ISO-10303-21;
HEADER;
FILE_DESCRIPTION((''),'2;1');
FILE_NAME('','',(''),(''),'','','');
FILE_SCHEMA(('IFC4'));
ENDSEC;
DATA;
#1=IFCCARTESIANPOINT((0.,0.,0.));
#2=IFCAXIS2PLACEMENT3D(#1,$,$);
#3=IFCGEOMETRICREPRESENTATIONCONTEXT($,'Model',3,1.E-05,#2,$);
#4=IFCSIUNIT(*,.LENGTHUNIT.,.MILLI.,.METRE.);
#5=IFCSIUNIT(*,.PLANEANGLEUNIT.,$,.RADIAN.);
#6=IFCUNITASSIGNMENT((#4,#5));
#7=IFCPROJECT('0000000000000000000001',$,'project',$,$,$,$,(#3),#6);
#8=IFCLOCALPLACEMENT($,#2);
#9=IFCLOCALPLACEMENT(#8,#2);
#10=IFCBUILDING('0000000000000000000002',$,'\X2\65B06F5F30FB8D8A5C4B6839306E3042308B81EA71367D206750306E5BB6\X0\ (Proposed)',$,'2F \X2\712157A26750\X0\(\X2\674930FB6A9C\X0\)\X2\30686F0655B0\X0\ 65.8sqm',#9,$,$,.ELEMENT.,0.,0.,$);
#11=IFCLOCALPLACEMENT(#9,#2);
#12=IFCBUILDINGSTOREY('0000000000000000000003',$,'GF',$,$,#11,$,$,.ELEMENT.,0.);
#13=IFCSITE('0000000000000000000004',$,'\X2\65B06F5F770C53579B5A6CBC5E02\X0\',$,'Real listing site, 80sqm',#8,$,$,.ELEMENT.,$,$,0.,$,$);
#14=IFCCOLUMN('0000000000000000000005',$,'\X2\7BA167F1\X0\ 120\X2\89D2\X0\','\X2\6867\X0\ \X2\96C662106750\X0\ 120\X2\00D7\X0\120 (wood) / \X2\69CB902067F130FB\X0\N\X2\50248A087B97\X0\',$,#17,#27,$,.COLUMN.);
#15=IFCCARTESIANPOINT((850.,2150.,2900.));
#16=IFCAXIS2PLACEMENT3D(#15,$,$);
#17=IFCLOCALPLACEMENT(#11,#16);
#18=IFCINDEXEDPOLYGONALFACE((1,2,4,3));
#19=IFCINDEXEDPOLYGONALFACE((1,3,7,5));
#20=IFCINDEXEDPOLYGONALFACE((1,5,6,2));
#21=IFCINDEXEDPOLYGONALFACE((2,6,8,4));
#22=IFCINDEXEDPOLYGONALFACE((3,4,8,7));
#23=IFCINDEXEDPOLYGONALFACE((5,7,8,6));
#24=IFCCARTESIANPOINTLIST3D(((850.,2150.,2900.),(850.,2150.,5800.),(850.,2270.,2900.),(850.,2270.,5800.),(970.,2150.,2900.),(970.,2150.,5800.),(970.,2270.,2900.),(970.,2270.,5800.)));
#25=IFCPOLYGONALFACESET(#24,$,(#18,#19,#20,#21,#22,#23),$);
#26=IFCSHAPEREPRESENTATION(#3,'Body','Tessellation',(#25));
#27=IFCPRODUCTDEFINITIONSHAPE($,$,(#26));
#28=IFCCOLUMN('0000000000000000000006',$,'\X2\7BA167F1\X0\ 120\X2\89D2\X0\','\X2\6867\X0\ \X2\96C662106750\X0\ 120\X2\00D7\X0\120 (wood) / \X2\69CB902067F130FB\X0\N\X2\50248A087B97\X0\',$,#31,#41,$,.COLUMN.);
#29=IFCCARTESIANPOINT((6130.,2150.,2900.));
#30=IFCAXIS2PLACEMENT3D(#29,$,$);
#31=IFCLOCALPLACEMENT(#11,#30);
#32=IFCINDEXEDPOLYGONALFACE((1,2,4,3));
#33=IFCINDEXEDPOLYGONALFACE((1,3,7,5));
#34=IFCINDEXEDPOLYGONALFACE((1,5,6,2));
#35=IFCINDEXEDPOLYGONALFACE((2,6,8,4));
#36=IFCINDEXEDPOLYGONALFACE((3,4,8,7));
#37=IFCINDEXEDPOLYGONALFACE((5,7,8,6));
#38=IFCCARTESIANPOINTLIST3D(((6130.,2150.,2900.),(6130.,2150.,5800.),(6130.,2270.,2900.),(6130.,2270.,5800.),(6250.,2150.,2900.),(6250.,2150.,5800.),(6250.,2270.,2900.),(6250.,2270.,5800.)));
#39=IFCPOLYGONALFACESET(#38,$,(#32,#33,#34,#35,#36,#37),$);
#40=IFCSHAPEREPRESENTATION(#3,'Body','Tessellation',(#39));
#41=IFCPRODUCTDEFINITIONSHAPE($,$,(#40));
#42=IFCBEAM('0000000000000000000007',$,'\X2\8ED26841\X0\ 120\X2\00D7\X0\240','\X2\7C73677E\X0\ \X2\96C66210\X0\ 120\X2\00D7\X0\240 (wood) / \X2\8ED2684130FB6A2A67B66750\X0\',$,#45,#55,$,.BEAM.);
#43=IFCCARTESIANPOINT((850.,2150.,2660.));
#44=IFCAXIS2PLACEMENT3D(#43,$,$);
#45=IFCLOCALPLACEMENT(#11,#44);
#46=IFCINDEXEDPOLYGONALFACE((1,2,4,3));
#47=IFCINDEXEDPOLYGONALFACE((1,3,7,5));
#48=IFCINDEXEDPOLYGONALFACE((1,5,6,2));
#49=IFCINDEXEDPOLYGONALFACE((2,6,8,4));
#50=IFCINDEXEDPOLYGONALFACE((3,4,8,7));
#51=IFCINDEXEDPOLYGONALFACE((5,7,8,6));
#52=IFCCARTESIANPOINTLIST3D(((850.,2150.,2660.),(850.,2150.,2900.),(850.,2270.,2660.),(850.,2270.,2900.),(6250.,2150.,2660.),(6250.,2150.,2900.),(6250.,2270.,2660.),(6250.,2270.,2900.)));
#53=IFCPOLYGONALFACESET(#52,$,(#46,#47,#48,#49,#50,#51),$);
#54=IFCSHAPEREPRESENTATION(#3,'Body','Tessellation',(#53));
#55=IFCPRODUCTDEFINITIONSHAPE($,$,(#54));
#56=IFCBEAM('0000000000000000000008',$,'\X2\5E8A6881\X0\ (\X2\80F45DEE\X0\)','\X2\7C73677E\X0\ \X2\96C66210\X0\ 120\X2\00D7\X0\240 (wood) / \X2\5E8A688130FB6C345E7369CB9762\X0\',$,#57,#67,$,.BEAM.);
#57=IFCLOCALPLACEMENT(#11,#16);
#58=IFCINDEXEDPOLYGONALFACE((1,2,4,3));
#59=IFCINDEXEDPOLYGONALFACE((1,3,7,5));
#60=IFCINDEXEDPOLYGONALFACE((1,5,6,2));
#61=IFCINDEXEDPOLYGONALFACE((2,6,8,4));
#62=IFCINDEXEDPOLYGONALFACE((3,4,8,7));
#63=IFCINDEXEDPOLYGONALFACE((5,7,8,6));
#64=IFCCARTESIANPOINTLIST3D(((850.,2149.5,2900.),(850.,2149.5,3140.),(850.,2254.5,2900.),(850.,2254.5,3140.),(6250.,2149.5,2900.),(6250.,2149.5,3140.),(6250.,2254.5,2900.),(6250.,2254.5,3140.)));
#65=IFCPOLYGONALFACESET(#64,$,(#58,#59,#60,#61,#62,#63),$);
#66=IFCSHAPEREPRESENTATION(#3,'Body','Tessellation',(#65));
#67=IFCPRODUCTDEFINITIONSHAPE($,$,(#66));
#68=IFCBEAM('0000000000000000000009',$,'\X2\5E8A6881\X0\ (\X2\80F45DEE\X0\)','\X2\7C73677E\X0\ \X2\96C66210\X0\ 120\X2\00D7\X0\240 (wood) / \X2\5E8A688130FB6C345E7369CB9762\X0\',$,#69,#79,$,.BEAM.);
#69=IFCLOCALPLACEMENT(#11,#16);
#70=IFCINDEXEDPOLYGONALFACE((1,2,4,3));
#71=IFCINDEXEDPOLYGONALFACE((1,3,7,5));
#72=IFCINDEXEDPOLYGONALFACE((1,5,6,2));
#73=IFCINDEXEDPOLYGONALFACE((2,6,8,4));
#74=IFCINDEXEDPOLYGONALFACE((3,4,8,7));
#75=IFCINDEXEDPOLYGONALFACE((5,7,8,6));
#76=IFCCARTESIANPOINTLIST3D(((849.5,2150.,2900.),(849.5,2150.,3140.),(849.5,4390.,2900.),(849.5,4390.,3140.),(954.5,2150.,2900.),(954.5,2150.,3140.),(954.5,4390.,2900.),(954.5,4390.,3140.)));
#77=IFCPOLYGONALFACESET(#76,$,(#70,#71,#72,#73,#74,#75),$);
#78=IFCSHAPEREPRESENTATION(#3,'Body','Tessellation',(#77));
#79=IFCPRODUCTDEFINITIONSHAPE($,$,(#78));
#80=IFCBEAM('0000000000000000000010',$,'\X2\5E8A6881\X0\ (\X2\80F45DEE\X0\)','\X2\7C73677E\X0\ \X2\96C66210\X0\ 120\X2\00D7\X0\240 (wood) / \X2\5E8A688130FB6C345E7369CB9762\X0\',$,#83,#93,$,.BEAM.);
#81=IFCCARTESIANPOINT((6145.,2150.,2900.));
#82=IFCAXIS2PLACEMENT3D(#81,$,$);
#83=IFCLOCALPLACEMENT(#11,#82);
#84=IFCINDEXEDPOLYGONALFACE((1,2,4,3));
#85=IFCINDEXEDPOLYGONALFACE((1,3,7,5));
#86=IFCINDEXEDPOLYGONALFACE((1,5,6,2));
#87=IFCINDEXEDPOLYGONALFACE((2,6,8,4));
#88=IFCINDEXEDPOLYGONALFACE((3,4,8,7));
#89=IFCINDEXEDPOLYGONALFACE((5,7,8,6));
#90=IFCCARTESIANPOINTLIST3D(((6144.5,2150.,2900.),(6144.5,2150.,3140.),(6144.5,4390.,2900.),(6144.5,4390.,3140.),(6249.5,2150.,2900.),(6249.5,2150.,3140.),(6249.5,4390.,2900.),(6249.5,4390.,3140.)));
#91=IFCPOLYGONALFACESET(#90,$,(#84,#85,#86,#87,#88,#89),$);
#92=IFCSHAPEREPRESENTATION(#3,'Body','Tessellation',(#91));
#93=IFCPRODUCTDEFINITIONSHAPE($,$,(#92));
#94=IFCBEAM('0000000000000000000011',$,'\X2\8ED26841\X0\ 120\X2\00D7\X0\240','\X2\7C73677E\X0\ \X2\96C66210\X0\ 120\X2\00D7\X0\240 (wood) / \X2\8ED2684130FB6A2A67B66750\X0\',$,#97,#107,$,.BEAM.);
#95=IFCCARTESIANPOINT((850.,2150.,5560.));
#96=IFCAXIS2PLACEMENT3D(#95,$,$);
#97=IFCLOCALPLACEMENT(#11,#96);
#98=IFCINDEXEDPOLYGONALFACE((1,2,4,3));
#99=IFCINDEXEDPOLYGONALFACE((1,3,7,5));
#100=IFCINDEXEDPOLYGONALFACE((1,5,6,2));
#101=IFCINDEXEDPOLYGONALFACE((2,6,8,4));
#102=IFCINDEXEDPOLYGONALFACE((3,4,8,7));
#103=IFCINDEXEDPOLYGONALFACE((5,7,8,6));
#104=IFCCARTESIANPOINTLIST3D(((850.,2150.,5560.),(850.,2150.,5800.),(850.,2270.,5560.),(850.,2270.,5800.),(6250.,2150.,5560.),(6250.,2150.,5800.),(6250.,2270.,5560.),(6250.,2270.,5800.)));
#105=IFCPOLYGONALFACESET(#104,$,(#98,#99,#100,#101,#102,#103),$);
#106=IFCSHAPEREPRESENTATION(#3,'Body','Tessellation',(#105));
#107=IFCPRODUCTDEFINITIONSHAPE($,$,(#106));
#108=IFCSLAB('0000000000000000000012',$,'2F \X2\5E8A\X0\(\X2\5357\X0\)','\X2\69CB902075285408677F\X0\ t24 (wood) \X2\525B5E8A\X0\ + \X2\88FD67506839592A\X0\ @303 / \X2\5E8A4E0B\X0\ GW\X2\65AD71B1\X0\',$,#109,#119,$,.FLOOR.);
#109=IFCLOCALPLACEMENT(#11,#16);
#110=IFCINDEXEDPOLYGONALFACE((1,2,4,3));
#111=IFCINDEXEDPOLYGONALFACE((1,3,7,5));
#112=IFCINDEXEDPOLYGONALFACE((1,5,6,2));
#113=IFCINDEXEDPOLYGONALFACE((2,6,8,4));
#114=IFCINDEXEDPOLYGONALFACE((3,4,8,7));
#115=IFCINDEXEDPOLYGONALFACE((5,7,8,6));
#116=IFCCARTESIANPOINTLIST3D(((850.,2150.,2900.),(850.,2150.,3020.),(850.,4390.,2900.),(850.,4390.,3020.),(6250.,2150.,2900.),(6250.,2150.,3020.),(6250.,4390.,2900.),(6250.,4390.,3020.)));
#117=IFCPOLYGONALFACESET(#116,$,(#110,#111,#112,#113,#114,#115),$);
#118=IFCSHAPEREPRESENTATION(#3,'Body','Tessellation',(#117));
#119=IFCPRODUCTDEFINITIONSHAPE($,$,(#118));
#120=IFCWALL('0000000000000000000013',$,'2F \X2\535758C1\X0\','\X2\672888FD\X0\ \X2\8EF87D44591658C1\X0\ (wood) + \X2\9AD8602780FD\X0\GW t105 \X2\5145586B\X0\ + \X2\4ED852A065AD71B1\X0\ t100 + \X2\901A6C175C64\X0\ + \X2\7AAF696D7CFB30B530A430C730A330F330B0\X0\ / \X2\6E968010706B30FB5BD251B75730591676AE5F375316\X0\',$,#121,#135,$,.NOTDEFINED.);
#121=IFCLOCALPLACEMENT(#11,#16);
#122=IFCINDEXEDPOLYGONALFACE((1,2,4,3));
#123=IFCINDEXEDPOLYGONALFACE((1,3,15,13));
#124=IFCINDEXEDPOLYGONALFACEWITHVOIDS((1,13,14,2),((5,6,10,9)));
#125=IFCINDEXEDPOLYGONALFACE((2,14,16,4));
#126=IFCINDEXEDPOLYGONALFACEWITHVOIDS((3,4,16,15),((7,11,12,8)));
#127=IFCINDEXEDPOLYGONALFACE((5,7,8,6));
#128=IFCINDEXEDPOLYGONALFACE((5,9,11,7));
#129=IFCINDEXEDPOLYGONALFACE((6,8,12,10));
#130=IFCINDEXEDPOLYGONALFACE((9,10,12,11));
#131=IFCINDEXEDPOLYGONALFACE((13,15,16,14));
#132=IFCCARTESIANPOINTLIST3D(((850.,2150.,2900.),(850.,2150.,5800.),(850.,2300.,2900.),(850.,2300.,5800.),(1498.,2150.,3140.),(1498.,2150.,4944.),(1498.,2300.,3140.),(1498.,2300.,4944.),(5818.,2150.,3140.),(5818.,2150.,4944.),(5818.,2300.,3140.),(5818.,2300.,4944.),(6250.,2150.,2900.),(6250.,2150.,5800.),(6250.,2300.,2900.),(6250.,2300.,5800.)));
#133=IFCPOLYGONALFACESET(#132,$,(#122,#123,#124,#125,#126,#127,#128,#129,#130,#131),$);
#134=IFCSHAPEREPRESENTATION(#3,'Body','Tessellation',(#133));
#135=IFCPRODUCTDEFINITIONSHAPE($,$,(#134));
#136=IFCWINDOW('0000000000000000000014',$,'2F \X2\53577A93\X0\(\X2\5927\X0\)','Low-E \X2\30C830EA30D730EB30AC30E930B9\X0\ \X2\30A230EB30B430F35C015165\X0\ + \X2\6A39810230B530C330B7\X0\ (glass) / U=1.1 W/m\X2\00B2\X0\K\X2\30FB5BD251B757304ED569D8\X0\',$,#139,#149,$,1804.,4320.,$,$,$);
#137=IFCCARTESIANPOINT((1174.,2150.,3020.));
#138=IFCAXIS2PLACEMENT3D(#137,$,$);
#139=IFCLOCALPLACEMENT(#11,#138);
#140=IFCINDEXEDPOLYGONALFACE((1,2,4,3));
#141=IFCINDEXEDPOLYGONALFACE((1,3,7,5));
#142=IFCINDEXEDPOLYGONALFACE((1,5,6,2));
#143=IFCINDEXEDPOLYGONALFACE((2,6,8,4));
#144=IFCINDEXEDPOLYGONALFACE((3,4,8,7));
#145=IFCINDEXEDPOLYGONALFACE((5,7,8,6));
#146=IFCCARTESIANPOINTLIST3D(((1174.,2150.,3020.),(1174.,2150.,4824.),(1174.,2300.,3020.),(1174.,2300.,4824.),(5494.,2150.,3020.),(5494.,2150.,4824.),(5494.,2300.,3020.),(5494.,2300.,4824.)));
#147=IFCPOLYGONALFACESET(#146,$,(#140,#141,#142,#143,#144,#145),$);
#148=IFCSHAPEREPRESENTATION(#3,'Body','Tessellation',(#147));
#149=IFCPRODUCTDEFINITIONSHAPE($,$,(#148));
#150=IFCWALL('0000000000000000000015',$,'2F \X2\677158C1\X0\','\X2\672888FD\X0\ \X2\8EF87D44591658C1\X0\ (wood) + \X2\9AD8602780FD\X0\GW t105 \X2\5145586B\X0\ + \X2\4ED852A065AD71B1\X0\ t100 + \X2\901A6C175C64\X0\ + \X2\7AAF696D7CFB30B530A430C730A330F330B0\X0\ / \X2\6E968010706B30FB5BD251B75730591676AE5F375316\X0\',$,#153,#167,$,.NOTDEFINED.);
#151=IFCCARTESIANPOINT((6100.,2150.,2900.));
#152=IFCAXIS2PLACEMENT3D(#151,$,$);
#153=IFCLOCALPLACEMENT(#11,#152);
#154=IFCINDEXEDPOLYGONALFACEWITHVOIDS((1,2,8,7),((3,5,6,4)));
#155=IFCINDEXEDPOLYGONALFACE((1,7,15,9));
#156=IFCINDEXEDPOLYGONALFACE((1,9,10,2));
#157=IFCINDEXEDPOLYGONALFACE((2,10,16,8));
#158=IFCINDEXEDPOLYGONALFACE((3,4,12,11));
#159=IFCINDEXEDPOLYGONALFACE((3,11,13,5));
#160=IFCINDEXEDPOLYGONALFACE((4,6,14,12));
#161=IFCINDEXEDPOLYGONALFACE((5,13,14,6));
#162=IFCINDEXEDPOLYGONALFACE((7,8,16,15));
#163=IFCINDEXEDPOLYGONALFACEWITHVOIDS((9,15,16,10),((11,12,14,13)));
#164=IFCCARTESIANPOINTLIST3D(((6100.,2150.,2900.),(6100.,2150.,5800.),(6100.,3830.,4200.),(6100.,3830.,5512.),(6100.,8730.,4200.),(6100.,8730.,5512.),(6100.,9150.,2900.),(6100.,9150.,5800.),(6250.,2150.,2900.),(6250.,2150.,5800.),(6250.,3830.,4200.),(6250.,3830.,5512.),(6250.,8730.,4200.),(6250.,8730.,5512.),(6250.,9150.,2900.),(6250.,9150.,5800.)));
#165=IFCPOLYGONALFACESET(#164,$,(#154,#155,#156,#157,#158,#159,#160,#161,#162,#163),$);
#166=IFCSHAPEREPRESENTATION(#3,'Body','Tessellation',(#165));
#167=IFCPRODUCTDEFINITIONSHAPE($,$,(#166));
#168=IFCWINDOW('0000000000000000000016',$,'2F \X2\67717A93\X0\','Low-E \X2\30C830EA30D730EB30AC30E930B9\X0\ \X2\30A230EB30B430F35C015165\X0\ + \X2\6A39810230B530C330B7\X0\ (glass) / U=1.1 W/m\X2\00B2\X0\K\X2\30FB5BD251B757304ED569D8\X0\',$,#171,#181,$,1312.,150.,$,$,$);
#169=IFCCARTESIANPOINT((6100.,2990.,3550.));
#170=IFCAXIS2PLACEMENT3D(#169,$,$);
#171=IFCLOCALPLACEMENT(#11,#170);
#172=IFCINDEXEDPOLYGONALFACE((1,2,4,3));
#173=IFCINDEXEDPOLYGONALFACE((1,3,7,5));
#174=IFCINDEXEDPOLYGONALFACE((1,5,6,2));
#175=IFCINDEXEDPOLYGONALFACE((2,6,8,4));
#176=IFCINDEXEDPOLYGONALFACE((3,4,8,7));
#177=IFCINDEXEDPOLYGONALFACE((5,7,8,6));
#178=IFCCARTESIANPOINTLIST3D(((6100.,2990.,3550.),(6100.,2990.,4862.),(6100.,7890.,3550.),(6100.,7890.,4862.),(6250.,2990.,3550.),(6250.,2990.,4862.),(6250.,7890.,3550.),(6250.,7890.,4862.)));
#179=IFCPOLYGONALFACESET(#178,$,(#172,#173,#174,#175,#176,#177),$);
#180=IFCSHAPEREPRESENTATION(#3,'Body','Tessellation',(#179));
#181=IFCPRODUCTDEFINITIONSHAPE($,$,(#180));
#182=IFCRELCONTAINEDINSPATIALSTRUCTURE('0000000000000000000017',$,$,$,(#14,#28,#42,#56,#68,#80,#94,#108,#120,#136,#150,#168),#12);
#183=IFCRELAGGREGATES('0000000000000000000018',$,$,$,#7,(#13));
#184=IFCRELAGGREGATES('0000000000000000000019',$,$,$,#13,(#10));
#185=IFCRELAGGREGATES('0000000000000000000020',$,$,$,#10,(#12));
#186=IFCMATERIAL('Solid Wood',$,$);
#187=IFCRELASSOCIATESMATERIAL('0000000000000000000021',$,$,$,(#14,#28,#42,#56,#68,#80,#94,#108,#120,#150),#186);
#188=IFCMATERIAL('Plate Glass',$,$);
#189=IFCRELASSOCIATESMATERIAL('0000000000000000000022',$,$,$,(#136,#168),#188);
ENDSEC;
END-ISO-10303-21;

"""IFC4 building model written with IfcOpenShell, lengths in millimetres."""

from ifc_helpers import new_model, si_unit, frame, frame_2d, origin, place, context, project, spatial, rectangle, extrude, material, element, fill, save


model = new_model("IFC4")

# Units and contexts
model_context = context("Model", 3, precision=1e-05, world=origin())
ifc_project = project(units=[si_unit("LENGTHUNIT", "METRE", prefix="MILLI"), si_unit("PLANEANGLEUNIT", "RADIAN")], contexts=[model_context])

# Site, building, storey
site_placement = place(None, origin())
site = spatial("IfcSite", under=ifc_project, at=site_placement, Name="新潟県南魚沼市", ObjectType="Real listing site, 80sqm", CompositionType="ELEMENT", RefElevation=0.0)
building_placement = place(site_placement, origin())
building = spatial("IfcBuilding", under=site, at=building_placement, Name="新潟・越屋根のある自然素材の家 (Proposed)", ObjectType="2F 無垢材(杉・檜)と漆喰 65.8sqm", CompositionType="ELEMENT", ElevationOfRefHeight=0.0, ElevationOfTerrain=0.0)
storey_placement = place(building_placement, origin())
storey = spatial("IfcBuildingStorey", under=building, at=storey_placement, Name="GF", CompositionType="ELEMENT", Elevation=0.0)

# Columns
ifc_material_1 = material(Name="Solid Wood")
column_1_placement = place(storey_placement, frame((850.0, 2150.0, 2900.0)))
element("IfcColumn", 1, at=column_1_placement, inside=storey, material=ifc_material_1, Name="管柱 120角", Description="桧 集成材 120×120 (wood) / 構造柱・N値計算", PredefinedType="COLUMN", context=model_context, shape_type="SweptSolid", body=[
    extrude(rectangle(XDim=120.0, YDim=120.0, at=frame_2d((60.0, 60.0))), frame((850.0, 2150.0, 2900.0)), (0.0, 0.0, 1.0), 2900.0),
])
column_2_placement = place(storey_placement, frame((6130.0, 2150.0, 2900.0)))
element("IfcColumn", 2, at=column_2_placement, inside=storey, material=ifc_material_1, Name="管柱 120角", Description="桧 集成材 120×120 (wood) / 構造柱・N値計算", PredefinedType="COLUMN", context=model_context, shape_type="SweptSolid", body=[
    extrude(rectangle(XDim=120.0, YDim=120.0, at=frame_2d((60.0, 60.0))), frame((6130.0, 2150.0, 2900.0)), (0.0, 0.0, 1.0), 2900.0),
])

# Beams
beam_1_placement = place(storey_placement, frame((850.0, 2150.0, 2660.0)))
element("IfcBeam", 3, at=beam_1_placement, inside=storey, material=ifc_material_1, Name="軒桁 120×240", Description="米松 集成 120×240 (wood) / 軒桁・横架材", PredefinedType="BEAM", context=model_context, shape_type="SweptSolid", body=[
    extrude(rectangle(XDim=5400.0, YDim=120.0, at=frame_2d((2700.0, 60.0))), frame((850.0, 2150.0, 2660.0)), (0.0, 0.0, 1.0), 240.0),
])
beam_2_placement = place(storey_placement, frame((850.0, 2150.0, 2900.0)))
element("IfcBeam", 4, at=beam_2_placement, inside=storey, material=ifc_material_1, Name="床梁 (胴差)", Description="米松 集成 120×240 (wood) / 床梁・水平構面", PredefinedType="BEAM", context=model_context, shape_type="SweptSolid", body=[
    extrude(rectangle(XDim=5400.0, YDim=105.0, at=frame_2d((2700.0, 52.0))), frame((850.0, 2150.0, 2900.0)), (0.0, 0.0, 1.0), 240.0),
])
beam_3_placement = place(storey_placement, frame((850.0, 2150.0, 2900.0)))
element("IfcBeam", 5, at=beam_3_placement, inside=storey, material=ifc_material_1, Name="床梁 (胴差)", Description="米松 集成 120×240 (wood) / 床梁・水平構面", PredefinedType="BEAM", context=model_context, shape_type="SweptSolid", body=[
    extrude(rectangle(XDim=105.0, YDim=2240.0, at=frame_2d((52.0, 1120.0))), frame((850.0, 2150.0, 2900.0)), (0.0, 0.0, 1.0), 240.0),
])
beam_4_placement = place(storey_placement, frame((6145.0, 2150.0, 2900.0)))
element("IfcBeam", 6, at=beam_4_placement, inside=storey, material=ifc_material_1, Name="床梁 (胴差)", Description="米松 集成 120×240 (wood) / 床梁・水平構面", PredefinedType="BEAM", context=model_context, shape_type="SweptSolid", body=[
    extrude(rectangle(XDim=105.0, YDim=2240.0, at=frame_2d((52.0, 1120.0))), frame((6145.0, 2150.0, 2900.0)), (0.0, 0.0, 1.0), 240.0),
])
beam_5_placement = place(storey_placement, frame((850.0, 2150.0, 5560.0)))
element("IfcBeam", 7, at=beam_5_placement, inside=storey, material=ifc_material_1, Name="軒桁 120×240", Description="米松 集成 120×240 (wood) / 軒桁・横架材", PredefinedType="BEAM", context=model_context, shape_type="SweptSolid", body=[
    extrude(rectangle(XDim=5400.0, YDim=120.0, at=frame_2d((2700.0, 60.0))), frame((850.0, 2150.0, 5560.0)), (0.0, 0.0, 1.0), 240.0),
])

# Slab
slab_placement = place(storey_placement, frame((850.0, 2150.0, 2900.0)))
element("IfcSlab", 8, at=slab_placement, inside=storey, material=ifc_material_1, Name="2F 床(南)", Description="構造用合板 t24 (wood) 剛床 + 製材根太 @303 / 床下 GW断熱", PredefinedType="FLOOR", context=model_context, shape_type="SweptSolid", body=[
    extrude(rectangle(XDim=5400.0, YDim=2240.0, at=frame_2d((2700.0, 1120.0))), frame((850.0, 2150.0, 2900.0)), (0.0, 0.0, 1.0), 120.0),
])

# Walls, openings, windows
wall_1_placement = place(storey_placement, frame((850.0, 2150.0, 2900.0)))
wall_1 = element("IfcWall", 9, at=wall_1_placement, inside=storey, material=ifc_material_1, Name="2F 南壁", Description="木製 軸組外壁 (wood) + 高性能GW t105 充填 + 付加断熱 t100 + 通気層 + 窯業系サイディング / 準耐火・寒冷地外皮強化", PredefinedType="NOTDEFINED", context=model_context, shape_type="SweptSolid", body=[
    extrude(rectangle(XDim=5400.0, YDim=150.0, at=frame_2d((2700.0, 75.0))), frame((850.0, 2150.0, 2900.0)), (0.0, 0.0, 1.0), 2900.0),
])
opening_1_placement = place(storey_placement, frame((1174.0, 2150.0, 3020.0)))
opening_1 = element("IfcOpeningElement", 10, at=opening_1_placement, cuts=wall_1, PredefinedType="NOTDEFINED", context=model_context, shape_type="SweptSolid", body=[
    extrude(rectangle(XDim=4320.0, YDim=150.0, at=frame_2d((2160.0, 75.0))), frame((1174.0, 2150.0, 3020.0)), (0.0, 0.0, 1.0), 1804.0),
])
ifc_material_2 = material(Name="Plate Glass")
window_1_placement = place(storey_placement, frame((1174.0, 2150.0, 3020.0)))
window_1 = element("IfcWindow", 11, at=window_1_placement, inside=storey, material=ifc_material_2, Name="2F 南窓(大)", Description="Low-E トリプルガラス アルゴン封入 + 樹脂サッシ (glass) / U=1.1 W/m²K・寒冷地仕様", OverallHeight=1804.0, OverallWidth=4320.0, context=model_context, shape_type="SweptSolid", body=[
    extrude(rectangle(XDim=4320.0, YDim=150.0, at=frame_2d((2160.0, 75.0))), frame((1174.0, 2150.0, 3020.0)), (0.0, 0.0, 1.0), 1804.0),
])
fill(opening_1, window_1)
wall_2_placement = place(storey_placement, frame((6100.0, 2150.0, 2900.0)))
wall_2 = element("IfcWall", 12, at=wall_2_placement, inside=storey, material=ifc_material_1, Name="2F 東壁", Description="木製 軸組外壁 (wood) + 高性能GW t105 充填 + 付加断熱 t100 + 通気層 + 窯業系サイディング / 準耐火・寒冷地外皮強化", PredefinedType="NOTDEFINED", context=model_context, shape_type="SweptSolid", body=[
    extrude(rectangle(XDim=150.0, YDim=7000.0, at=frame_2d((75.0, 3500.0))), frame((6100.0, 2150.0, 2900.0)), (0.0, 0.0, 1.0), 2900.0),
])
opening_2_placement = place(storey_placement, frame((6100.0, 2990.0, 3550.0)))
opening_2 = element("IfcOpeningElement", 13, at=opening_2_placement, cuts=wall_2, PredefinedType="NOTDEFINED", context=model_context, shape_type="SweptSolid", body=[
    extrude(rectangle(XDim=150.0, YDim=4900.0, at=frame_2d((75.0, 2450.0))), frame((6100.0, 2990.0, 3550.0)), (0.0, 0.0, 1.0), 1312.0),
])
window_2_placement = place(storey_placement, frame((6100.0, 2990.0, 3550.0)))
window_2 = element("IfcWindow", 14, at=window_2_placement, inside=storey, material=ifc_material_2, Name="2F 東窓", Description="Low-E トリプルガラス アルゴン封入 + 樹脂サッシ (glass) / U=1.1 W/m²K・寒冷地仕様", OverallHeight=1312.0, OverallWidth=150.0, context=model_context, shape_type="SweptSolid", body=[
    extrude(rectangle(XDim=150.0, YDim=4900.0, at=frame_2d((75.0, 2450.0))), frame((6100.0, 2990.0, 3550.0)), (0.0, 0.0, 1.0), 1312.0),
])
fill(opening_2, window_2)

save(model, "model.ifc")
